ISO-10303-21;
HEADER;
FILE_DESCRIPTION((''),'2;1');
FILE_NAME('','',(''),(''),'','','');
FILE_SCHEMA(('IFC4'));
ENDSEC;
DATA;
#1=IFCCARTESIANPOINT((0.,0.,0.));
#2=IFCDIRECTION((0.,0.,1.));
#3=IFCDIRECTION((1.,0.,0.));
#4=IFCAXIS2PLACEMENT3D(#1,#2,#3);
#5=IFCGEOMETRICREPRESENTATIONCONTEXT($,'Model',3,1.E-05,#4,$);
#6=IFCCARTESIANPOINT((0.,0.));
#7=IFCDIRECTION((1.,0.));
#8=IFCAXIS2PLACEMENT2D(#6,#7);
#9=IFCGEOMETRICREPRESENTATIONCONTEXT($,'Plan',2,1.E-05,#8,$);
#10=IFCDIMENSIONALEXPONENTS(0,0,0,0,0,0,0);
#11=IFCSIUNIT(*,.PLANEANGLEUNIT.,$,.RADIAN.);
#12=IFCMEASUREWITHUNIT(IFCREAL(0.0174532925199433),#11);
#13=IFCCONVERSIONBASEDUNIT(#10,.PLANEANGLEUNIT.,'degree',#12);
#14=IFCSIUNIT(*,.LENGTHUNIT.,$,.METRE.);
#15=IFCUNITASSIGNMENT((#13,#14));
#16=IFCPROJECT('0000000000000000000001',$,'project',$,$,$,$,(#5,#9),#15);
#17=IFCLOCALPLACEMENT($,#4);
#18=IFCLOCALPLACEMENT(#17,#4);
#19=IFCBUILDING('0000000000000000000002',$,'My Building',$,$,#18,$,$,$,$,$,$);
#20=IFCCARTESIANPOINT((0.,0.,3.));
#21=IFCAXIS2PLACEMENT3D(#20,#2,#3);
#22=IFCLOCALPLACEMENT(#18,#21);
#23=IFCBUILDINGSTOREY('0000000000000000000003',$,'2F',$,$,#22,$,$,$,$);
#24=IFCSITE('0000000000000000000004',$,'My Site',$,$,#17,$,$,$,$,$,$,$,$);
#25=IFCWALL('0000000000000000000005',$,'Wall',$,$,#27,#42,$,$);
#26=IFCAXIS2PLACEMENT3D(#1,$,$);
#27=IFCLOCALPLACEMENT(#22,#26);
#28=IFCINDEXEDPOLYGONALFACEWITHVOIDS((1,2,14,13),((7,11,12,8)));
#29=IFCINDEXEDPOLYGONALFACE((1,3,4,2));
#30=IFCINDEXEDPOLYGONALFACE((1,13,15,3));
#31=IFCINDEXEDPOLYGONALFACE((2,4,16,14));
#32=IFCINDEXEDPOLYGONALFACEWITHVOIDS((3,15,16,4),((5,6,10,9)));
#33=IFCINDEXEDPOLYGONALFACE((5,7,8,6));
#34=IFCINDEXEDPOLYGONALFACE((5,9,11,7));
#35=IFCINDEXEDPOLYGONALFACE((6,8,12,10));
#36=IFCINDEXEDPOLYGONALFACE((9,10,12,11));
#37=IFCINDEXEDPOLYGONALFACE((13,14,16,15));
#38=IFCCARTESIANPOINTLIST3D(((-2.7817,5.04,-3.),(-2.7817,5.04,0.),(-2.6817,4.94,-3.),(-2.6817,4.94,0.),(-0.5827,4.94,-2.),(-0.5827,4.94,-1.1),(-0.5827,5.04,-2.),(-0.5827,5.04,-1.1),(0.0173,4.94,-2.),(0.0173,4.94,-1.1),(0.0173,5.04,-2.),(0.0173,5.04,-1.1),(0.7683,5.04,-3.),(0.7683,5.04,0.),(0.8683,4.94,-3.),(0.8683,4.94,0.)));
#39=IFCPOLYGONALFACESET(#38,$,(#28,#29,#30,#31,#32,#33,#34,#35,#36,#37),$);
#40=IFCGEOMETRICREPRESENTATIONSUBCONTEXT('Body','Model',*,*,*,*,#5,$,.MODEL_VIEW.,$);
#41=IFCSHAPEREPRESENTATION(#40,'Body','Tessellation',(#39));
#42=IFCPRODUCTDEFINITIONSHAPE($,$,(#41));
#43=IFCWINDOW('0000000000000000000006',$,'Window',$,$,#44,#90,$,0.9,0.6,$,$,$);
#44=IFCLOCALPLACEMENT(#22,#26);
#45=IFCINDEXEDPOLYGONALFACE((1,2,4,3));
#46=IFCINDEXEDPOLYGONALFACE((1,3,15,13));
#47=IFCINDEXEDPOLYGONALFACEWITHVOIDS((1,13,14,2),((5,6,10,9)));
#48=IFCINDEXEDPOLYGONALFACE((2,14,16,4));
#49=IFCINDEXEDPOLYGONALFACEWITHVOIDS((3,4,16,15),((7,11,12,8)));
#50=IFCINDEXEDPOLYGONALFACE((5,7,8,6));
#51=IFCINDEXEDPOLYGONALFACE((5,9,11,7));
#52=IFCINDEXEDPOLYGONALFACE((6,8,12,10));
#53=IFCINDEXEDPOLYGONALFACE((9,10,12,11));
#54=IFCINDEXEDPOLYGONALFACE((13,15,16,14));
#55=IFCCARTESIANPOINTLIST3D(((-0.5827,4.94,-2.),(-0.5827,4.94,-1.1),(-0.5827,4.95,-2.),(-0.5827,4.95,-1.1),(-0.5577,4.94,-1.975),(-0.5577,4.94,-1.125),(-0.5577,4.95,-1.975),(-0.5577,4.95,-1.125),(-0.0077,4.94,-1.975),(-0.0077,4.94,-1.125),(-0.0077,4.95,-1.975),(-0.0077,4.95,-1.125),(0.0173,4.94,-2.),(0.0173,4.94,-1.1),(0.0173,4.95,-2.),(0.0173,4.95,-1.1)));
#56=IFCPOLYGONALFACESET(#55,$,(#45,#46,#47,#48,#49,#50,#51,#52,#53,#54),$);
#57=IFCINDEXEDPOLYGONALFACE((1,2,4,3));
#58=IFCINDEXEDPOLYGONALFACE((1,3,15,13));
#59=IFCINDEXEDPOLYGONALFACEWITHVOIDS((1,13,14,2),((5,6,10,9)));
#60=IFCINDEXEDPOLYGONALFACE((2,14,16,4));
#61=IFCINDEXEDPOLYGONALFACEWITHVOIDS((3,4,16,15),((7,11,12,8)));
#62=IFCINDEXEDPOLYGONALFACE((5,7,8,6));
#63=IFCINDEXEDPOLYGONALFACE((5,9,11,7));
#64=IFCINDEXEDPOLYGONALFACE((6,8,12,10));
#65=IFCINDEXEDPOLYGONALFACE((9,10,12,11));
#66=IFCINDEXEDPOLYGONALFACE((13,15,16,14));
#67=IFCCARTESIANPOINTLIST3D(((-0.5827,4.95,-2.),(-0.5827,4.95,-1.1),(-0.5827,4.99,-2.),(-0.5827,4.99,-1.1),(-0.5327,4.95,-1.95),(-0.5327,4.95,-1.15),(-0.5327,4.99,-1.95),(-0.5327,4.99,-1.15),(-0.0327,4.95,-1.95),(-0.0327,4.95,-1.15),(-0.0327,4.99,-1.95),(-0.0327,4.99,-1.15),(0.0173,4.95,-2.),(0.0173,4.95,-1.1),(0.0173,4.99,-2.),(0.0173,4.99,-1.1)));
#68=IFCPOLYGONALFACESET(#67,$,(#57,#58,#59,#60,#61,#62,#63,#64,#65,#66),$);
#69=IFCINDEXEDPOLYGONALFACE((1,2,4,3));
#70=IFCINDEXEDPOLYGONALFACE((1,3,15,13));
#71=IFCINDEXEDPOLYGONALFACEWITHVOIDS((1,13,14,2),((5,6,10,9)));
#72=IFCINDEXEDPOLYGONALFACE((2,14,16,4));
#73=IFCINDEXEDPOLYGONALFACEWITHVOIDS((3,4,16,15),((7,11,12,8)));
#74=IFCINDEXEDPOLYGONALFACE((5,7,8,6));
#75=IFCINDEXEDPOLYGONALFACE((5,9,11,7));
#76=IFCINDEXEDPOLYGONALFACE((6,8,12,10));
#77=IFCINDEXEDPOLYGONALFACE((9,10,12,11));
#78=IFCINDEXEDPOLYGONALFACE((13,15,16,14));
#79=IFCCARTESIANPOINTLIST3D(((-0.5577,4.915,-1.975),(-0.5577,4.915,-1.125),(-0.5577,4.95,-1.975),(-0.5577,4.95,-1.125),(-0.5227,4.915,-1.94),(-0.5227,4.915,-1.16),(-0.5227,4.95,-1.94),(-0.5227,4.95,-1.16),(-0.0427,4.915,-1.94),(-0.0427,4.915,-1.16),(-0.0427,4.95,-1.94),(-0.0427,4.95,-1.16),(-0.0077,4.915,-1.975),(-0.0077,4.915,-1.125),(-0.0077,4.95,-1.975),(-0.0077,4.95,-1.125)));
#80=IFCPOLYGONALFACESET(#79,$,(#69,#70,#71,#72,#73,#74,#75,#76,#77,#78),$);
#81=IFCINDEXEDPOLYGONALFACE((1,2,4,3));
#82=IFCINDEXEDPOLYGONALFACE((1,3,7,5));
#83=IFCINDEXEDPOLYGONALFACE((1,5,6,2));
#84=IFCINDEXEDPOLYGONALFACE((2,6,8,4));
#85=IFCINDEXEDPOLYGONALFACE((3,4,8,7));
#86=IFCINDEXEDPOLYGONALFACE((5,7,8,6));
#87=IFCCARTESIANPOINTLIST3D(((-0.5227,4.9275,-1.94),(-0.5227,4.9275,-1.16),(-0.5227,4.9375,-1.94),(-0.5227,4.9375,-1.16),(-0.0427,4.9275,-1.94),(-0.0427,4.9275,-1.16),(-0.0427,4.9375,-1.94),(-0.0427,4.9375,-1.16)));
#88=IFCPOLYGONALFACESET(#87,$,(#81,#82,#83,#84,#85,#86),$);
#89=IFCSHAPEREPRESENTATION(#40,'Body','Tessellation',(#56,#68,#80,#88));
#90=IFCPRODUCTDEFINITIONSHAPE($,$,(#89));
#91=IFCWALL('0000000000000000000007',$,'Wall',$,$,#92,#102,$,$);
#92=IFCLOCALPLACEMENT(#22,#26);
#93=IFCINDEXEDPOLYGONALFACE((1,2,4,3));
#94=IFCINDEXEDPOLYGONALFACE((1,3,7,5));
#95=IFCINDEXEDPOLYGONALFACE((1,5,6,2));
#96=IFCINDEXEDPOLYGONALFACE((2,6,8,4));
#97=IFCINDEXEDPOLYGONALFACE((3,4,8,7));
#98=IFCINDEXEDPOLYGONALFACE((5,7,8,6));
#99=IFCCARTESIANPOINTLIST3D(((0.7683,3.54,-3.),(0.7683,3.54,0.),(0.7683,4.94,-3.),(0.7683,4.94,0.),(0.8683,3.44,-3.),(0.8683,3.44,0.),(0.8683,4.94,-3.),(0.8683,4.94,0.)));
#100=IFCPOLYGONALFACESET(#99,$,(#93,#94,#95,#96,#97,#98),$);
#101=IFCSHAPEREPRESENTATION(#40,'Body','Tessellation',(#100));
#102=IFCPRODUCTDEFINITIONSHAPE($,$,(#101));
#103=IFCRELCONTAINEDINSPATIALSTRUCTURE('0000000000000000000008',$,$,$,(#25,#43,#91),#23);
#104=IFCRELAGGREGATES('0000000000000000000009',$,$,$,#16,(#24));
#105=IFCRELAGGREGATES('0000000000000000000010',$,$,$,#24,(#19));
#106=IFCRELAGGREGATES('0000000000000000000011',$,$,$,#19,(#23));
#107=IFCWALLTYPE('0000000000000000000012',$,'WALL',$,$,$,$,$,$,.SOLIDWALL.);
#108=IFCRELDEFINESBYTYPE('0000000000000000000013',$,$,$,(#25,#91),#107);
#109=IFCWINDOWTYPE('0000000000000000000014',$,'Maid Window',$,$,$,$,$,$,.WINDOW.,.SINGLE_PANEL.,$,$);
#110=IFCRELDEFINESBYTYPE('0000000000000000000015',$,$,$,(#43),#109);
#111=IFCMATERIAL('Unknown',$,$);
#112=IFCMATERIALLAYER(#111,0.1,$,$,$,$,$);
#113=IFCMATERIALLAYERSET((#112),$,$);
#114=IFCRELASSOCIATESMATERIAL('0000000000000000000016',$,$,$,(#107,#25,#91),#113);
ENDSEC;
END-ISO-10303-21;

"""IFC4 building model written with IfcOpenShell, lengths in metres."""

from ifc_helpers import new_model, entity, si_unit, converted_unit, frame, origin_with_axes, origin_2d_with_axis, place, context, subcontext, project, spatial, line, indexed_curve, outline, extrude, shape, source, transform, mapped, material, layer, layer_set, layer_usage, type_object, type_shapes, element, fill, save


model = new_model("IFC4")

# Units and contexts
model_context = context("Model", 3, precision=1e-05, world=origin_with_axes())
plan_context = context("Plan", 2, precision=1e-05, world=origin_2d_with_axis())
body_context_1 = subcontext(model_context, "Body", "Model", "MODEL_VIEW")
body_context_2 = subcontext(plan_context, "Body", "Plan", "PLAN_VIEW")
ifc_project = project(units=[converted_unit("PLANEANGLEUNIT", "degree", entity("IfcReal", 0.0174532925199433), si_unit("PLANEANGLEUNIT", "RADIAN"), dimensions=[0, 0, 0, 0, 0, 0, 0]), si_unit("LENGTHUNIT", "METRE")], contexts=[model_context, plan_context])

# Site, building, storey
site_placement = place(None, origin_with_axes())
site = spatial("IfcSite", under=ifc_project, at=site_placement, Name="My Site")
building_placement = place(site_placement, origin_with_axes())
building = spatial("IfcBuilding", under=site, at=building_placement, Name="My Building")
storey_placement = place(building_placement, frame((0.0, 0.0, 3.0), z_axis=(0.0, 0.0, 1.0), x_axis=(1.0, 0.0, 0.0)))
storey = spatial("IfcBuildingStorey", under=building, at=storey_placement, Name="2F")

# Shared definitions
ifc_material = material(Name="Unknown")
ifc_layer_1 = layer(ifc_material, 0.1)
ifc_layer_set_1 = layer_set([ifc_layer_1])
wall_type_1 = type_object("IfcWallType", Name="WALL", PredefinedType="SOLIDWALL", material=ifc_layer_set_1)

# Wall, opening, window
ifc_layer_usage_1 = layer_usage(ifc_layer_set_1, "AXIS2", "POSITIVE", 0.0)
wall_1_placement = place(storey_placement, frame((0.7683, 5.04, -3.0), z_axis=(0.0, 0.0, 1.0), x_axis=(-1.0, 0.0, 0.0)))
wall_1 = element("IfcWall", 1, at=wall_1_placement, inside=storey, type_object=wall_type_1, material=ifc_layer_usage_1, Name="Wall", context=body_context_1, shape_type="SweptSolid", body=[
    extrude(outline(indexed_curve([(0.0, 0.0), (-0.1, 0.1), (3.45, 0.1), (3.55, 0.0)], segments=[line(1, 2, 3, 4, 1)])), origin_with_axes(), (0.0, 0.0, 1.0), 3.0),
])
shared_shape_1 = source(origin_with_axes(), body_context_1, "Body", "SweptSolid", [
    extrude(outline(indexed_curve([(0.0, 0.0), (0.6, 0.0), (0.6, 0.9), (0.0, 0.9)], segments=[line(1, 2, 3, 4, 1)])), frame((0.0, -0.6, 0.0), z_axis=(0.0, -1.0, 0.0), x_axis=(1.0, 0.0, 0.0)), (0.0, 0.0, -1.0), 1.2),
])
opening_1_placement = place(wall_1_placement, frame((0.751, 0.0, 1.0), z_axis=(0.0, 0.0, 1.0), x_axis=(1.0, 0.0, 0.0)))
opening_1 = element("IfcOpeningElement", 2, at=opening_1_placement, cuts=wall_1, PredefinedType="OPENING", context=body_context_1, shape_type="MappedRepresentation", body=[
    mapped(shared_shape_1, transform((0.0, 0.0, 0.0), x_axis=(1.0, 0.0, 0.0), y_axis=(0.0, 1.0, 0.0), z_axis=(0.0, 0.0, 1.0), scale=1.0)),
])
window_type = type_object("IfcWindowType", Name="Maid Window", PartitioningType="SINGLE_PANEL", PredefinedType="WINDOW")
shared_shape_2 = source(origin_with_axes(), body_context_1, "Body", "SweptSolid", [
    extrude(outline(indexed_curve([(0.0, 0.0), (0.6, 0.0), (0.6, 0.9), (0.0, 0.9)], segments=[line(1, 2, 3, 4, 1)]), holes=[indexed_curve([(0.025, 0.025), (0.575, 0.025), (0.575, 0.875), (0.025, 0.875)], segments=[line(1, 2, 3, 4, 1)])]), frame((0.0, 0.09, 0.0), z_axis=(0.0, -1.0, 0.0), x_axis=(1.0, 0.0, 0.0)), (0.0, 0.0, -1.0), 0.01),
    extrude(outline(indexed_curve([(0.0, 0.0), (0.6, 0.0), (0.6, 0.9), (0.0, 0.9)], segments=[line(1, 2, 3, 4, 1)]), holes=[indexed_curve([(0.05, 0.05), (0.55, 0.05), (0.55, 0.85), (0.05, 0.85)], segments=[line(1, 2, 3, 4, 1)])]), frame((0.0, 0.05, 0.0), z_axis=(0.0, -1.0, 0.0), x_axis=(1.0, 0.0, 0.0)), (0.0, 0.0, -1.0), 0.04),
    extrude(outline(indexed_curve([(0.0, 0.0), (0.55, 0.0), (0.55, 0.85), (0.0, 0.85)], segments=[line(1, 2, 3, 4, 1)]), holes=[indexed_curve([(0.035, 0.035), (0.515, 0.035), (0.515, 0.815), (0.035, 0.815)], segments=[line(1, 2, 3, 4, 1)])]), frame((0.025, 0.09, 0.025), z_axis=(0.0, -1.0, 0.0), x_axis=(1.0, 0.0, 0.0)), (0.0, 0.0, -1.0), 0.035),
    extrude(outline(indexed_curve([(0.035, 0.035), (0.515, 0.035), (0.515, 0.815), (0.035, 0.815)], segments=[line(1, 2, 3, 4, 1)])), frame((0.025, 0.1025, 0.025), z_axis=(0.0, -1.0, 0.0), x_axis=(1.0, 0.0, 0.0)), (0.0, 0.0, -1.0), 0.01),
])
shared_shape_3 = source(origin_with_axes(), body_context_2, "Body", "Curve2D", [
    entity("IfcIndexedPolyCurve", entity("IfcCartesianPointList2D", [[0.05, 0.05], [0.55, 0.05]])),
    entity("IfcIndexedPolyCurve", entity("IfcCartesianPointList2D", [[0.0, 0.1], [0.025, 0.1], [0.025, 0.09], [0.05, 0.09], [0.05, 0.05], [0.0, 0.05]]), [entity("IfcLineIndex", [1, 2, 3, 4, 5, 6, 1])]),
    entity("IfcIndexedPolyCurve", entity("IfcCartesianPointList2D", [[0.6, 0.1], [0.575, 0.1], [0.575, 0.09], [0.55, 0.09], [0.55, 0.05], [0.6, 0.05]]), [entity("IfcLineIndex", [1, 2, 3, 4, 5, 6, 1])]),
    entity("IfcIndexedPolyCurve", entity("IfcCartesianPointList2D", [[0.025, 0.09], [0.06, 0.09], [0.06, 0.125], [0.025, 0.125]]), [entity("IfcLineIndex", [1, 2, 3, 4, 1])]),
    entity("IfcIndexedPolyCurve", entity("IfcCartesianPointList2D", [[0.575, 0.09], [0.54, 0.09], [0.54, 0.125], [0.575, 0.125]]), [entity("IfcLineIndex", [1, 2, 3, 4, 1])]),
    entity("IfcIndexedPolyCurve", entity("IfcCartesianPointList2D", [[0.06, 0.09], [0.54, 0.09]])),
    entity("IfcIndexedPolyCurve", entity("IfcCartesianPointList2D", [[0.06, 0.125], [0.54, 0.125]])),
    entity("IfcIndexedPolyCurve", entity("IfcCartesianPointList2D", [[0.06, 0.1075], [0.54, 0.1075]])),
])
type_shapes(window_type, [shared_shape_2, shared_shape_3])
window_placement = place(opening_1_placement, frame((0.0, 0.0, 0.0), z_axis=(0.0, 0.0, 1.0), x_axis=(1.0, 0.0, 0.0)))
window = element("IfcWindow", 3, at=window_placement, inside=storey, type_object=window_type, Name="Window", OverallHeight=0.9, OverallWidth=0.6, shapes=[
    shape(body_context_1, "Body", "MappedRepresentation", [mapped(shared_shape_2, transform((0.0, 0.0, 0.0), x_axis=(1.0, 0.0, 0.0), y_axis=(0.0, 1.0, 0.0), z_axis=(0.0, 0.0, 1.0), scale=1.0))]),
    shape(body_context_2, "Body", "MappedRepresentation", [mapped(shared_shape_3, transform((0.0, 0.0, 0.0), x_axis=(1.0, 0.0, 0.0), y_axis=(0.0, 1.0, 0.0), z_axis=(0.0, 0.0, 1.0), scale=1.0))]),
])
fill(opening_1, window)

# Wall
ifc_layer_usage_2 = layer_usage(ifc_layer_set_1, "AXIS2", "POSITIVE", 0.0)
wall_2_placement = place(storey_placement, frame((0.7683, 4.94, -3.0), z_axis=(0.0, 0.0, 1.0), x_axis=(0.0, -1.0, 0.0)))
element("IfcWall", 4, at=wall_2_placement, inside=storey, type_object=wall_type_1, material=ifc_layer_usage_2, Name="Wall", context=body_context_1, shape_type="SweptSolid", body=[
    extrude(outline(indexed_curve([(0.0, 0.0), (0.0, 0.1), (1.5, 0.1), (1.4, 0.0)], segments=[line(1, 2, 3, 4, 1)])), origin_with_axes(), (0.0, 0.0, 1.0), 3.0),
])

save(model, "model.ifc")
